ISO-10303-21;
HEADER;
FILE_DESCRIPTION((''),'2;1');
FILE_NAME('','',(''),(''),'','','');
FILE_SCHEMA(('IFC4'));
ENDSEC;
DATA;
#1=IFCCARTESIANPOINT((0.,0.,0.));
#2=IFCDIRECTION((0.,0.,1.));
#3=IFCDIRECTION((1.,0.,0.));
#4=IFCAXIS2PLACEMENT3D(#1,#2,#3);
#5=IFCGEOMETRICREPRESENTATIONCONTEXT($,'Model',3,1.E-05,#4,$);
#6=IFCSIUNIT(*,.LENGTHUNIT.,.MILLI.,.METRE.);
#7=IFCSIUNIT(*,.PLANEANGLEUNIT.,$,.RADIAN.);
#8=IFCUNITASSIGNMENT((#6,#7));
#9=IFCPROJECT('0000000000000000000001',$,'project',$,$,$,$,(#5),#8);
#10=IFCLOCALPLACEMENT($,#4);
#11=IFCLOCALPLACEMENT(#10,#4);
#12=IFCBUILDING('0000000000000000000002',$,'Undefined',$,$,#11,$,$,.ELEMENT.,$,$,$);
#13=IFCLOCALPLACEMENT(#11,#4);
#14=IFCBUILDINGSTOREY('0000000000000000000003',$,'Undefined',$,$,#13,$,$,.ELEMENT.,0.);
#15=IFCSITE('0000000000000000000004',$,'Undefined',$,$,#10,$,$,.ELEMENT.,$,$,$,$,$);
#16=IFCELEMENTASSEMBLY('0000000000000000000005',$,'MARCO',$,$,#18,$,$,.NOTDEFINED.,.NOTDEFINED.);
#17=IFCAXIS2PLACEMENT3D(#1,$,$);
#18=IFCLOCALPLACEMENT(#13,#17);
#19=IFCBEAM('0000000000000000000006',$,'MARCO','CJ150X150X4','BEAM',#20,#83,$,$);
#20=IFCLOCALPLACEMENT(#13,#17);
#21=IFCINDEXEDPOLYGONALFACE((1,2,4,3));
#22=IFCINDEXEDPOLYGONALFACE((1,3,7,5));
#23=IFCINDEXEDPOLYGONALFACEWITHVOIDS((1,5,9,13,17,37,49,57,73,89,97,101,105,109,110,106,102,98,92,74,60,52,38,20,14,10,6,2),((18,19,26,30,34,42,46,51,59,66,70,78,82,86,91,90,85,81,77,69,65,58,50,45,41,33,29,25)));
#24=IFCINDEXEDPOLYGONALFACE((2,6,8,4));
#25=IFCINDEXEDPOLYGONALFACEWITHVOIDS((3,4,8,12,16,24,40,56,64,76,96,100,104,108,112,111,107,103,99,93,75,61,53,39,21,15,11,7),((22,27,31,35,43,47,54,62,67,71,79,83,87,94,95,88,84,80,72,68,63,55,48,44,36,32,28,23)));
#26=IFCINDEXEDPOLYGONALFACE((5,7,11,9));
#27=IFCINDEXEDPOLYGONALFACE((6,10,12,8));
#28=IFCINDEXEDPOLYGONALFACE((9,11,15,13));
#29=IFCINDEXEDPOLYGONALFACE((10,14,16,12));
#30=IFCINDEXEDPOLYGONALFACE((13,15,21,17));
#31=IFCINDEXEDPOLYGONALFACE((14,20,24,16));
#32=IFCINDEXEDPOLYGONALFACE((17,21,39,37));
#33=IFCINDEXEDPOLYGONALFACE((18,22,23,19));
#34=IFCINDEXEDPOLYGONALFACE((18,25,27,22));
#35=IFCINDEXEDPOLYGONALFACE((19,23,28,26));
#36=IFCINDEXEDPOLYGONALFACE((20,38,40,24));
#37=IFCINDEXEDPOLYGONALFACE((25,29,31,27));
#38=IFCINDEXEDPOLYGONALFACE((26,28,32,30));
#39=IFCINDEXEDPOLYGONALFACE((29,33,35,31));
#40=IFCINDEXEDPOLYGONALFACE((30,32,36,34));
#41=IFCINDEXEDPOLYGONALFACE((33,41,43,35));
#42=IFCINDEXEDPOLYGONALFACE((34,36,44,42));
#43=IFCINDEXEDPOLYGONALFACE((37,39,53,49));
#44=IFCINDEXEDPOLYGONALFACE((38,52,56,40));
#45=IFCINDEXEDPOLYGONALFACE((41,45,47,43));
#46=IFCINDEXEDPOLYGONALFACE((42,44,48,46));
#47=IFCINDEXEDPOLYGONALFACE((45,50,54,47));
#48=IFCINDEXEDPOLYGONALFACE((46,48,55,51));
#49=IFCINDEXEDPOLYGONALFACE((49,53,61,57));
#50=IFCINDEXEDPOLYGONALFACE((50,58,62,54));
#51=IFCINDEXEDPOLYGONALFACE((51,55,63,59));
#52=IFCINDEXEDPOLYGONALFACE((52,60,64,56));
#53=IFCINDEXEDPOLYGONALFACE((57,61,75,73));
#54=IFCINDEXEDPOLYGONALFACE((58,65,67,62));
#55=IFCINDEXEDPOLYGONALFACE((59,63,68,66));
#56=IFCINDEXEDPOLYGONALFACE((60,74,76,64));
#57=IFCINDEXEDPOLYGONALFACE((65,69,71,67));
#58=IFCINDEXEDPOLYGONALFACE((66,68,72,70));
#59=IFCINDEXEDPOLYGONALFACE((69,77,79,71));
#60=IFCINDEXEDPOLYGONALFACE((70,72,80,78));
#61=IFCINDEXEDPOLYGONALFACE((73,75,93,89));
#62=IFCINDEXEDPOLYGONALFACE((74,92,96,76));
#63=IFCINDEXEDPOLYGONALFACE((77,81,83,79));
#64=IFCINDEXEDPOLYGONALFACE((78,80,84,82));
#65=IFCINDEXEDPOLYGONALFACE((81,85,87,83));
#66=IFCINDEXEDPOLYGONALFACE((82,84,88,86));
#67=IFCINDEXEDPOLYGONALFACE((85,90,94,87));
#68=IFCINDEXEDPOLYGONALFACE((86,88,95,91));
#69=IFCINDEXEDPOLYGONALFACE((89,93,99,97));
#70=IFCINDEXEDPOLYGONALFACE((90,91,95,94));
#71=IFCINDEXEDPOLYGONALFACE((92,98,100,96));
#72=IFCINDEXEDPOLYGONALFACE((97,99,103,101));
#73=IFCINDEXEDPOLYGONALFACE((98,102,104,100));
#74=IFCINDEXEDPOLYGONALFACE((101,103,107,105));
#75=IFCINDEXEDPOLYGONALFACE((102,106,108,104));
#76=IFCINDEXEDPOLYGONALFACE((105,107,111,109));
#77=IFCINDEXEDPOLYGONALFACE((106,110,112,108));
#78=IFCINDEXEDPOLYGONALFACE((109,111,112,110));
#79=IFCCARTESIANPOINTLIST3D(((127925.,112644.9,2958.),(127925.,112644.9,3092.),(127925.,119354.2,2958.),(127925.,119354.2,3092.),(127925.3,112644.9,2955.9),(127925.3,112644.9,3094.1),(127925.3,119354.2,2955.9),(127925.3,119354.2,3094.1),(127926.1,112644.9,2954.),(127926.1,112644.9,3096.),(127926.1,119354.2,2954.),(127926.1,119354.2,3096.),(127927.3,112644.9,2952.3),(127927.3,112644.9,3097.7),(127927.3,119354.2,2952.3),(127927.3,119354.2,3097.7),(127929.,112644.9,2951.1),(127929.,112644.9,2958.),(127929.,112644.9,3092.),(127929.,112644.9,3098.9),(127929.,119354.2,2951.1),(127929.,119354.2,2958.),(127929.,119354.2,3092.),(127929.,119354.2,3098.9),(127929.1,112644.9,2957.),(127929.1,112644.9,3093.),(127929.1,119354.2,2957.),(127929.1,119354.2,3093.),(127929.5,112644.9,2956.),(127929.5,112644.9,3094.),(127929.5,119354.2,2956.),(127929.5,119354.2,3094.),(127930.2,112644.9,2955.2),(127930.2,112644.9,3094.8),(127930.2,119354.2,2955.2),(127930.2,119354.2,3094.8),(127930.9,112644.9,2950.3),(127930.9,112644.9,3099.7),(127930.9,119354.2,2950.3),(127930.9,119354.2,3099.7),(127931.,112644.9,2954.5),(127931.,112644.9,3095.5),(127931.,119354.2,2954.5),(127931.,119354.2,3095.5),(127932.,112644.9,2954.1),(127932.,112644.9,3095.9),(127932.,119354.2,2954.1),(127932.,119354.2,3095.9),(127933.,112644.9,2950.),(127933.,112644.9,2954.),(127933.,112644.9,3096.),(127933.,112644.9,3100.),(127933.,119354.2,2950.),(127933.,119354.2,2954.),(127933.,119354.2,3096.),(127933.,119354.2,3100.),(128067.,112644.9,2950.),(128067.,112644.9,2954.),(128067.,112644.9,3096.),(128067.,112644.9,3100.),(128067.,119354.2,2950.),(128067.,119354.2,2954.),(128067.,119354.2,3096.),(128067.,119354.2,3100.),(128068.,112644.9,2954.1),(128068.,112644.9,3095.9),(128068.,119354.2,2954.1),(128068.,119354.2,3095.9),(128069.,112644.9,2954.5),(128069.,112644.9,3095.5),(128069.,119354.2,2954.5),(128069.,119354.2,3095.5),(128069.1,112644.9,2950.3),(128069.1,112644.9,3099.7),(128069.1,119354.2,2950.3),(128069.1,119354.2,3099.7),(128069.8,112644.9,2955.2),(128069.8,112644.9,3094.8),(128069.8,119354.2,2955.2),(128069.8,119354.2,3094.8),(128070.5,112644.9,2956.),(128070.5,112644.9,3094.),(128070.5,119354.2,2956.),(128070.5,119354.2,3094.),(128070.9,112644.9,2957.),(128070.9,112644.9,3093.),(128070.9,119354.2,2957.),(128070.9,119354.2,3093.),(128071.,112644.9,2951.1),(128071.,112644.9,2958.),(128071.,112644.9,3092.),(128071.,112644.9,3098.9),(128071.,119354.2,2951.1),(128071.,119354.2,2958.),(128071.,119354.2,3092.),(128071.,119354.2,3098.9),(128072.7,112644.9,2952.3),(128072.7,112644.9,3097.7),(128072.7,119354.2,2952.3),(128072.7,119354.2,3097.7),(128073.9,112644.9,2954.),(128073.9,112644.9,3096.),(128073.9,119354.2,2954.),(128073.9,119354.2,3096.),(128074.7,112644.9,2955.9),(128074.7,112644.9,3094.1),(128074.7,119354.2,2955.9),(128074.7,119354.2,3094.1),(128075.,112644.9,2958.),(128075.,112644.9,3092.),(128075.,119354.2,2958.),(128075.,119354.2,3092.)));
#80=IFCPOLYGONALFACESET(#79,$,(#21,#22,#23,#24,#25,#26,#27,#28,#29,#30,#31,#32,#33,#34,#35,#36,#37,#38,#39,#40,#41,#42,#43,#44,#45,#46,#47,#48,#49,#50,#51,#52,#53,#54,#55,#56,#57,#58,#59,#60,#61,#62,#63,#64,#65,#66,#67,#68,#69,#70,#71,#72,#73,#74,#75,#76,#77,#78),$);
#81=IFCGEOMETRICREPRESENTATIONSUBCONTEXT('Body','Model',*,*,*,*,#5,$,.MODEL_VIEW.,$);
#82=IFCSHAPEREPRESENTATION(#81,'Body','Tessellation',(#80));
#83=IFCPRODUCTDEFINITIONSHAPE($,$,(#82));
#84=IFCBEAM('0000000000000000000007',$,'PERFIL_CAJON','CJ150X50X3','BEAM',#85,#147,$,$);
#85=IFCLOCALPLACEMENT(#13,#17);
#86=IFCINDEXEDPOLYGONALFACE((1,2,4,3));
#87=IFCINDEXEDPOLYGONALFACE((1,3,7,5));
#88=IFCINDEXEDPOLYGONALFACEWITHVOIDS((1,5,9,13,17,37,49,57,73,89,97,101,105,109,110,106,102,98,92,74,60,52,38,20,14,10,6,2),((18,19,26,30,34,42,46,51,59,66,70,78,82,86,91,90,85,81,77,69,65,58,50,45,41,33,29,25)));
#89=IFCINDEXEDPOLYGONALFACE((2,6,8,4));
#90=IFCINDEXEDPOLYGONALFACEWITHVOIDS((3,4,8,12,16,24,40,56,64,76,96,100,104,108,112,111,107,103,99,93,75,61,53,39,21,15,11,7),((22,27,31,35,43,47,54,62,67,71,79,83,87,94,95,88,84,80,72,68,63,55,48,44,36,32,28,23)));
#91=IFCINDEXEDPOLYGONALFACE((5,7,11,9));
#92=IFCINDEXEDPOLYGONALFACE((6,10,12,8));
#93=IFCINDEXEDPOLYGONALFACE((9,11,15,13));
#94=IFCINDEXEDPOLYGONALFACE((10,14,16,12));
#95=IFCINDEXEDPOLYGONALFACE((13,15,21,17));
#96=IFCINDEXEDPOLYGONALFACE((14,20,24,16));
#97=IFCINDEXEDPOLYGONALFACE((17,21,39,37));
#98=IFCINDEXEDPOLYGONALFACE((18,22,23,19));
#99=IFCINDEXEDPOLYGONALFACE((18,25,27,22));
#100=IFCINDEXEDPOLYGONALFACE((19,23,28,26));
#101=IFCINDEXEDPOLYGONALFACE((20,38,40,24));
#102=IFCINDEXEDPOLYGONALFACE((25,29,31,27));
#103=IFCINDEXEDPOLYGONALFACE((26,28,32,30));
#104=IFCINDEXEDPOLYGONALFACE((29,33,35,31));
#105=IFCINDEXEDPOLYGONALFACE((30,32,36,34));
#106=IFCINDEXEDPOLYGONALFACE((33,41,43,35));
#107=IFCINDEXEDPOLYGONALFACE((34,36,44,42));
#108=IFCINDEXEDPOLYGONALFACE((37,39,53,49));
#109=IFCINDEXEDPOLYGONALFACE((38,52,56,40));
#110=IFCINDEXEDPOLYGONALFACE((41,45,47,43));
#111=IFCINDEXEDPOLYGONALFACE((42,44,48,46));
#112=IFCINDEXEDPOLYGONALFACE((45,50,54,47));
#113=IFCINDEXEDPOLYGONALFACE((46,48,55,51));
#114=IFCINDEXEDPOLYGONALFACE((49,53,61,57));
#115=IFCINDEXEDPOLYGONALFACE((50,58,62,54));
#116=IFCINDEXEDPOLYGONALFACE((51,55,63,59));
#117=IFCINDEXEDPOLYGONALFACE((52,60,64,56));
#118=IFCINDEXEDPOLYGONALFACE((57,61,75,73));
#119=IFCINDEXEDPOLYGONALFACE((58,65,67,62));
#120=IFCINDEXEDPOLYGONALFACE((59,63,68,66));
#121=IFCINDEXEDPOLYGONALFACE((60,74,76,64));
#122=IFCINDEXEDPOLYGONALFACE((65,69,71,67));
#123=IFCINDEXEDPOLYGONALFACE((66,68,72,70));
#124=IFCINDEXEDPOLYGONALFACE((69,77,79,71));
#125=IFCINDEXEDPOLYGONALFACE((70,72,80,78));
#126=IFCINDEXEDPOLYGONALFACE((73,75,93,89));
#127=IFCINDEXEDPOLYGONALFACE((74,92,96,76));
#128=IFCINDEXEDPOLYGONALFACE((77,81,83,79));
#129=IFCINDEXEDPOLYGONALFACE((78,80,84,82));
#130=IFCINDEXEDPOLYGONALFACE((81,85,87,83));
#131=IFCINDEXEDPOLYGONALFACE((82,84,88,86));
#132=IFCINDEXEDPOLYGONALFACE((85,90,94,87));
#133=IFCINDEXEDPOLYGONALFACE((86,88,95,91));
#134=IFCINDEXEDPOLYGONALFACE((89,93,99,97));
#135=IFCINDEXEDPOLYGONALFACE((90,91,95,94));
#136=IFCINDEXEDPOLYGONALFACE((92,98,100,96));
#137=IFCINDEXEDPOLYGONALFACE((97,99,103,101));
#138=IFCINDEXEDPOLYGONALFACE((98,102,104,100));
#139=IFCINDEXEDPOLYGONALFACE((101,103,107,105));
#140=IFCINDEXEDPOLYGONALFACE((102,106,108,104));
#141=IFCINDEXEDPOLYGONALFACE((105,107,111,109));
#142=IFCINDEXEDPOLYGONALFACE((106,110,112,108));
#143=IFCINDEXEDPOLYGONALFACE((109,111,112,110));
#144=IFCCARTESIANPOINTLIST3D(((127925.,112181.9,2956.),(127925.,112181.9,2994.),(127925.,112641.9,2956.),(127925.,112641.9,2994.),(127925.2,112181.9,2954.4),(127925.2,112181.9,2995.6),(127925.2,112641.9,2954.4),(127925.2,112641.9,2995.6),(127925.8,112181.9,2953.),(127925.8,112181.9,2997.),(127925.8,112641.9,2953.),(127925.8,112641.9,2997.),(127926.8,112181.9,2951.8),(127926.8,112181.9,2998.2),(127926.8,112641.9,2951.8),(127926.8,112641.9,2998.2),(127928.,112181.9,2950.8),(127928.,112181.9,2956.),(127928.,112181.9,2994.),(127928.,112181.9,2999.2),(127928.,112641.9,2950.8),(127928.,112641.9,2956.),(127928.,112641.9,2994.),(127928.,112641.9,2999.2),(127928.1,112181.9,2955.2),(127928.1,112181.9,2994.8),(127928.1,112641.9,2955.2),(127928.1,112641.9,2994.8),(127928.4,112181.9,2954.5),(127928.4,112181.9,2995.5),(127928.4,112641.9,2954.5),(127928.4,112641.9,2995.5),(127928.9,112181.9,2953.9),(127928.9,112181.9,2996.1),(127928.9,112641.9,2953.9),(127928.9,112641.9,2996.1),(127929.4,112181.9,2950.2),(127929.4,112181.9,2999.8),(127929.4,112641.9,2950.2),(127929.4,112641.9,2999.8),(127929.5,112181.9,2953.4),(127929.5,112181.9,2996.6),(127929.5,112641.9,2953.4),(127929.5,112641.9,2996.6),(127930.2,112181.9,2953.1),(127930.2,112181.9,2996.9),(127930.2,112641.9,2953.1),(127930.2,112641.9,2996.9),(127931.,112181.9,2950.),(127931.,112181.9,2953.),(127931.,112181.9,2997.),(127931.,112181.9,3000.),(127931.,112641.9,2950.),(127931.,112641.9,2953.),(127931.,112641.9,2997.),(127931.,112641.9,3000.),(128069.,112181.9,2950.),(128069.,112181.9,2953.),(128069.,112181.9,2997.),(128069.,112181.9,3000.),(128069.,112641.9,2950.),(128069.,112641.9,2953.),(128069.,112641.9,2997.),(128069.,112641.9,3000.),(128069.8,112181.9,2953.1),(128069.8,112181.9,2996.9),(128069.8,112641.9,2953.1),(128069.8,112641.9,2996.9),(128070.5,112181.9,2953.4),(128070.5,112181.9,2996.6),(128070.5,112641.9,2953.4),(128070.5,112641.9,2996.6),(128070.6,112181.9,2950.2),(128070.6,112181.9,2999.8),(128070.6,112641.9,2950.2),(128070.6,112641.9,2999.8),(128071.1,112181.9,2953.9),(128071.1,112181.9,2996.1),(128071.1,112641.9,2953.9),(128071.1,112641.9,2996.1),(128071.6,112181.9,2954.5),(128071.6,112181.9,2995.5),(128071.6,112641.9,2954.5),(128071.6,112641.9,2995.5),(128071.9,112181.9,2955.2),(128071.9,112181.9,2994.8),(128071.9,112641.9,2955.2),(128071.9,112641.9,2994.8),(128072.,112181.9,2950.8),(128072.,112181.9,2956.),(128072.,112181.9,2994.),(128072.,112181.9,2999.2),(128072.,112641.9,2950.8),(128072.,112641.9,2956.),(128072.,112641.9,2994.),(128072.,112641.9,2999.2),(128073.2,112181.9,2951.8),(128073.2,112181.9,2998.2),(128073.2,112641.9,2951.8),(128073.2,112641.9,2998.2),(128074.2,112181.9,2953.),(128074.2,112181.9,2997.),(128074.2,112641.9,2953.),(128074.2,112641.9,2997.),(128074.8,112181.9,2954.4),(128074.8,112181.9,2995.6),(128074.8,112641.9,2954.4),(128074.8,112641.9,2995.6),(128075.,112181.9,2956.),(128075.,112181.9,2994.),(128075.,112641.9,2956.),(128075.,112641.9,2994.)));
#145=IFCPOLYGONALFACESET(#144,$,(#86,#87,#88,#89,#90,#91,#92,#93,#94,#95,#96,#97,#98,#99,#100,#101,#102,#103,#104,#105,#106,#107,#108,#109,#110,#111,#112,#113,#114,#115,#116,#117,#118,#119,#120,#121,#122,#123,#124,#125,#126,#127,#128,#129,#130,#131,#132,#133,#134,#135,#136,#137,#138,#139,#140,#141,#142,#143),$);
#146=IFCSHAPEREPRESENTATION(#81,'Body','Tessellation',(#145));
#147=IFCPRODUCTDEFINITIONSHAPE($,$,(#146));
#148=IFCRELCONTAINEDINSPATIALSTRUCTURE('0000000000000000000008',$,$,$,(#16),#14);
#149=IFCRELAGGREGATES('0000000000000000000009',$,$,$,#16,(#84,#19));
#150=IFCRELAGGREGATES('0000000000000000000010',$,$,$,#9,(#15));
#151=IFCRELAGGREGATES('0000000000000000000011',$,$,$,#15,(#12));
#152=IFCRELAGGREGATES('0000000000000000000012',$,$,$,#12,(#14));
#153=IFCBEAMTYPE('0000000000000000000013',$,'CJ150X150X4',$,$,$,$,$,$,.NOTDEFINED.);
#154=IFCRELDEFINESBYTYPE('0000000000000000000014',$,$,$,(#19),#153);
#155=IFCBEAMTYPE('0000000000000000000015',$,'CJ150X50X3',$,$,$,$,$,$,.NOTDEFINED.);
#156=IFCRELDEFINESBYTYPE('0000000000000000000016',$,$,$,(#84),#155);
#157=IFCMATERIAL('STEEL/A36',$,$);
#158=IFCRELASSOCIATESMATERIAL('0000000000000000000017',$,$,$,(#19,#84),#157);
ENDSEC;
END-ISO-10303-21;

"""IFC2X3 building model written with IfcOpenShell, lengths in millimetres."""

from ifc_helpers import new_model, si_unit, frame, origin_with_axes, origin_2d_with_axis, place, context, subcontext, project, spatial, hollow_rectangle, extrude, material, type_object, element, aggregate, save


model = new_model("IFC2X3")

# Units and contexts
model_context = context("Model", 3, precision=1e-05, world=origin_with_axes())
body_context = subcontext(model_context, "Body", "Model", "MODEL_VIEW")
ifc_project = project(units=[si_unit("LENGTHUNIT", "METRE", prefix="MILLI"), si_unit("PLANEANGLEUNIT", "RADIAN")], contexts=[model_context])

# Site, building, storey
site_placement = place(None, origin_with_axes())
site = spatial("IfcSite", under=ifc_project, at=site_placement, Name="Undefined", CompositionType="ELEMENT")
building_placement = place(site_placement, origin_with_axes())
building = spatial("IfcBuilding", under=site, at=building_placement, Name="Undefined", CompositionType="ELEMENT")
storey_placement = place(building_placement, origin_with_axes())
storey = spatial("IfcBuildingStorey", under=building, at=storey_placement, Name="Undefined", CompositionType="ELEMENT", Elevation=0.0)

# Shared definitions
ifc_material_1 = material(Name="STEEL/A36")

# Element assembly, beams
assembly_1_placement = place(storey_placement, origin_with_axes())
assembly_1 = element("IfcElementAssembly", 1, at=assembly_1_placement, inside=storey, Name="MARCO", AssemblyPlace="NOTDEFINED", PredefinedType="NOTDEFINED")
beam_type_1 = type_object("IfcBeamType", Name="CJ150X150X4", PredefinedType="NOTDEFINED")
beam_1_placement = place(assembly_1_placement, frame((128000.0, 112644.9, 3025.0), z_axis=(0.0, 0.0, -1.0), x_axis=(0.0, 1.0, 0.0)))
beam_1 = element("IfcBeam", 2, at=beam_1_placement, type_object=beam_type_1, material=ifc_material_1, Name="MARCO", Description="CJ150X150X4", ObjectType="BEAM", context=body_context, shape_type="SweptSolid", body=[
    extrude(hollow_rectangle(XDim=150.0, YDim=150.0, WallThickness=4.0, InnerFilletRadius=4.0, OuterFilletRadius=8.0, at=origin_2d_with_axis()), frame((6709.3, 0.0, 0.0), z_axis=(-1.0, 0.0, 0.0), x_axis=(0.0, -1.0, 0.0)), (0.0, 0.0, 1.0), 6709.3),
])
beam_type_2 = type_object("IfcBeamType", Name="CJ150X50X3", PredefinedType="NOTDEFINED")
beam_2_placement = place(assembly_1_placement, frame((128000.0, 112181.9, 2975.0), z_axis=(1.0, 0.0, 0.0), x_axis=(0.0, 1.0, 0.0)))
beam_2 = element("IfcBeam", 3, at=beam_2_placement, type_object=beam_type_2, material=ifc_material_1, Name="PERFIL_CAJON", Description="CJ150X50X3", ObjectType="BEAM", context=body_context, shape_type="SweptSolid", body=[
    extrude(hollow_rectangle(XDim=50.0, YDim=150.0, WallThickness=3.0, InnerFilletRadius=3.0, OuterFilletRadius=6.0, at=origin_2d_with_axis()), frame((460.0, 0.0, 0.0), z_axis=(-1.0, 0.0, 0.0), x_axis=(0.0, -1.0, 0.0)), (0.0, 0.0, 1.0), 460.0),
])

aggregate(assembly_1, [beam_2, beam_1])

save(model, "model.ifc")
